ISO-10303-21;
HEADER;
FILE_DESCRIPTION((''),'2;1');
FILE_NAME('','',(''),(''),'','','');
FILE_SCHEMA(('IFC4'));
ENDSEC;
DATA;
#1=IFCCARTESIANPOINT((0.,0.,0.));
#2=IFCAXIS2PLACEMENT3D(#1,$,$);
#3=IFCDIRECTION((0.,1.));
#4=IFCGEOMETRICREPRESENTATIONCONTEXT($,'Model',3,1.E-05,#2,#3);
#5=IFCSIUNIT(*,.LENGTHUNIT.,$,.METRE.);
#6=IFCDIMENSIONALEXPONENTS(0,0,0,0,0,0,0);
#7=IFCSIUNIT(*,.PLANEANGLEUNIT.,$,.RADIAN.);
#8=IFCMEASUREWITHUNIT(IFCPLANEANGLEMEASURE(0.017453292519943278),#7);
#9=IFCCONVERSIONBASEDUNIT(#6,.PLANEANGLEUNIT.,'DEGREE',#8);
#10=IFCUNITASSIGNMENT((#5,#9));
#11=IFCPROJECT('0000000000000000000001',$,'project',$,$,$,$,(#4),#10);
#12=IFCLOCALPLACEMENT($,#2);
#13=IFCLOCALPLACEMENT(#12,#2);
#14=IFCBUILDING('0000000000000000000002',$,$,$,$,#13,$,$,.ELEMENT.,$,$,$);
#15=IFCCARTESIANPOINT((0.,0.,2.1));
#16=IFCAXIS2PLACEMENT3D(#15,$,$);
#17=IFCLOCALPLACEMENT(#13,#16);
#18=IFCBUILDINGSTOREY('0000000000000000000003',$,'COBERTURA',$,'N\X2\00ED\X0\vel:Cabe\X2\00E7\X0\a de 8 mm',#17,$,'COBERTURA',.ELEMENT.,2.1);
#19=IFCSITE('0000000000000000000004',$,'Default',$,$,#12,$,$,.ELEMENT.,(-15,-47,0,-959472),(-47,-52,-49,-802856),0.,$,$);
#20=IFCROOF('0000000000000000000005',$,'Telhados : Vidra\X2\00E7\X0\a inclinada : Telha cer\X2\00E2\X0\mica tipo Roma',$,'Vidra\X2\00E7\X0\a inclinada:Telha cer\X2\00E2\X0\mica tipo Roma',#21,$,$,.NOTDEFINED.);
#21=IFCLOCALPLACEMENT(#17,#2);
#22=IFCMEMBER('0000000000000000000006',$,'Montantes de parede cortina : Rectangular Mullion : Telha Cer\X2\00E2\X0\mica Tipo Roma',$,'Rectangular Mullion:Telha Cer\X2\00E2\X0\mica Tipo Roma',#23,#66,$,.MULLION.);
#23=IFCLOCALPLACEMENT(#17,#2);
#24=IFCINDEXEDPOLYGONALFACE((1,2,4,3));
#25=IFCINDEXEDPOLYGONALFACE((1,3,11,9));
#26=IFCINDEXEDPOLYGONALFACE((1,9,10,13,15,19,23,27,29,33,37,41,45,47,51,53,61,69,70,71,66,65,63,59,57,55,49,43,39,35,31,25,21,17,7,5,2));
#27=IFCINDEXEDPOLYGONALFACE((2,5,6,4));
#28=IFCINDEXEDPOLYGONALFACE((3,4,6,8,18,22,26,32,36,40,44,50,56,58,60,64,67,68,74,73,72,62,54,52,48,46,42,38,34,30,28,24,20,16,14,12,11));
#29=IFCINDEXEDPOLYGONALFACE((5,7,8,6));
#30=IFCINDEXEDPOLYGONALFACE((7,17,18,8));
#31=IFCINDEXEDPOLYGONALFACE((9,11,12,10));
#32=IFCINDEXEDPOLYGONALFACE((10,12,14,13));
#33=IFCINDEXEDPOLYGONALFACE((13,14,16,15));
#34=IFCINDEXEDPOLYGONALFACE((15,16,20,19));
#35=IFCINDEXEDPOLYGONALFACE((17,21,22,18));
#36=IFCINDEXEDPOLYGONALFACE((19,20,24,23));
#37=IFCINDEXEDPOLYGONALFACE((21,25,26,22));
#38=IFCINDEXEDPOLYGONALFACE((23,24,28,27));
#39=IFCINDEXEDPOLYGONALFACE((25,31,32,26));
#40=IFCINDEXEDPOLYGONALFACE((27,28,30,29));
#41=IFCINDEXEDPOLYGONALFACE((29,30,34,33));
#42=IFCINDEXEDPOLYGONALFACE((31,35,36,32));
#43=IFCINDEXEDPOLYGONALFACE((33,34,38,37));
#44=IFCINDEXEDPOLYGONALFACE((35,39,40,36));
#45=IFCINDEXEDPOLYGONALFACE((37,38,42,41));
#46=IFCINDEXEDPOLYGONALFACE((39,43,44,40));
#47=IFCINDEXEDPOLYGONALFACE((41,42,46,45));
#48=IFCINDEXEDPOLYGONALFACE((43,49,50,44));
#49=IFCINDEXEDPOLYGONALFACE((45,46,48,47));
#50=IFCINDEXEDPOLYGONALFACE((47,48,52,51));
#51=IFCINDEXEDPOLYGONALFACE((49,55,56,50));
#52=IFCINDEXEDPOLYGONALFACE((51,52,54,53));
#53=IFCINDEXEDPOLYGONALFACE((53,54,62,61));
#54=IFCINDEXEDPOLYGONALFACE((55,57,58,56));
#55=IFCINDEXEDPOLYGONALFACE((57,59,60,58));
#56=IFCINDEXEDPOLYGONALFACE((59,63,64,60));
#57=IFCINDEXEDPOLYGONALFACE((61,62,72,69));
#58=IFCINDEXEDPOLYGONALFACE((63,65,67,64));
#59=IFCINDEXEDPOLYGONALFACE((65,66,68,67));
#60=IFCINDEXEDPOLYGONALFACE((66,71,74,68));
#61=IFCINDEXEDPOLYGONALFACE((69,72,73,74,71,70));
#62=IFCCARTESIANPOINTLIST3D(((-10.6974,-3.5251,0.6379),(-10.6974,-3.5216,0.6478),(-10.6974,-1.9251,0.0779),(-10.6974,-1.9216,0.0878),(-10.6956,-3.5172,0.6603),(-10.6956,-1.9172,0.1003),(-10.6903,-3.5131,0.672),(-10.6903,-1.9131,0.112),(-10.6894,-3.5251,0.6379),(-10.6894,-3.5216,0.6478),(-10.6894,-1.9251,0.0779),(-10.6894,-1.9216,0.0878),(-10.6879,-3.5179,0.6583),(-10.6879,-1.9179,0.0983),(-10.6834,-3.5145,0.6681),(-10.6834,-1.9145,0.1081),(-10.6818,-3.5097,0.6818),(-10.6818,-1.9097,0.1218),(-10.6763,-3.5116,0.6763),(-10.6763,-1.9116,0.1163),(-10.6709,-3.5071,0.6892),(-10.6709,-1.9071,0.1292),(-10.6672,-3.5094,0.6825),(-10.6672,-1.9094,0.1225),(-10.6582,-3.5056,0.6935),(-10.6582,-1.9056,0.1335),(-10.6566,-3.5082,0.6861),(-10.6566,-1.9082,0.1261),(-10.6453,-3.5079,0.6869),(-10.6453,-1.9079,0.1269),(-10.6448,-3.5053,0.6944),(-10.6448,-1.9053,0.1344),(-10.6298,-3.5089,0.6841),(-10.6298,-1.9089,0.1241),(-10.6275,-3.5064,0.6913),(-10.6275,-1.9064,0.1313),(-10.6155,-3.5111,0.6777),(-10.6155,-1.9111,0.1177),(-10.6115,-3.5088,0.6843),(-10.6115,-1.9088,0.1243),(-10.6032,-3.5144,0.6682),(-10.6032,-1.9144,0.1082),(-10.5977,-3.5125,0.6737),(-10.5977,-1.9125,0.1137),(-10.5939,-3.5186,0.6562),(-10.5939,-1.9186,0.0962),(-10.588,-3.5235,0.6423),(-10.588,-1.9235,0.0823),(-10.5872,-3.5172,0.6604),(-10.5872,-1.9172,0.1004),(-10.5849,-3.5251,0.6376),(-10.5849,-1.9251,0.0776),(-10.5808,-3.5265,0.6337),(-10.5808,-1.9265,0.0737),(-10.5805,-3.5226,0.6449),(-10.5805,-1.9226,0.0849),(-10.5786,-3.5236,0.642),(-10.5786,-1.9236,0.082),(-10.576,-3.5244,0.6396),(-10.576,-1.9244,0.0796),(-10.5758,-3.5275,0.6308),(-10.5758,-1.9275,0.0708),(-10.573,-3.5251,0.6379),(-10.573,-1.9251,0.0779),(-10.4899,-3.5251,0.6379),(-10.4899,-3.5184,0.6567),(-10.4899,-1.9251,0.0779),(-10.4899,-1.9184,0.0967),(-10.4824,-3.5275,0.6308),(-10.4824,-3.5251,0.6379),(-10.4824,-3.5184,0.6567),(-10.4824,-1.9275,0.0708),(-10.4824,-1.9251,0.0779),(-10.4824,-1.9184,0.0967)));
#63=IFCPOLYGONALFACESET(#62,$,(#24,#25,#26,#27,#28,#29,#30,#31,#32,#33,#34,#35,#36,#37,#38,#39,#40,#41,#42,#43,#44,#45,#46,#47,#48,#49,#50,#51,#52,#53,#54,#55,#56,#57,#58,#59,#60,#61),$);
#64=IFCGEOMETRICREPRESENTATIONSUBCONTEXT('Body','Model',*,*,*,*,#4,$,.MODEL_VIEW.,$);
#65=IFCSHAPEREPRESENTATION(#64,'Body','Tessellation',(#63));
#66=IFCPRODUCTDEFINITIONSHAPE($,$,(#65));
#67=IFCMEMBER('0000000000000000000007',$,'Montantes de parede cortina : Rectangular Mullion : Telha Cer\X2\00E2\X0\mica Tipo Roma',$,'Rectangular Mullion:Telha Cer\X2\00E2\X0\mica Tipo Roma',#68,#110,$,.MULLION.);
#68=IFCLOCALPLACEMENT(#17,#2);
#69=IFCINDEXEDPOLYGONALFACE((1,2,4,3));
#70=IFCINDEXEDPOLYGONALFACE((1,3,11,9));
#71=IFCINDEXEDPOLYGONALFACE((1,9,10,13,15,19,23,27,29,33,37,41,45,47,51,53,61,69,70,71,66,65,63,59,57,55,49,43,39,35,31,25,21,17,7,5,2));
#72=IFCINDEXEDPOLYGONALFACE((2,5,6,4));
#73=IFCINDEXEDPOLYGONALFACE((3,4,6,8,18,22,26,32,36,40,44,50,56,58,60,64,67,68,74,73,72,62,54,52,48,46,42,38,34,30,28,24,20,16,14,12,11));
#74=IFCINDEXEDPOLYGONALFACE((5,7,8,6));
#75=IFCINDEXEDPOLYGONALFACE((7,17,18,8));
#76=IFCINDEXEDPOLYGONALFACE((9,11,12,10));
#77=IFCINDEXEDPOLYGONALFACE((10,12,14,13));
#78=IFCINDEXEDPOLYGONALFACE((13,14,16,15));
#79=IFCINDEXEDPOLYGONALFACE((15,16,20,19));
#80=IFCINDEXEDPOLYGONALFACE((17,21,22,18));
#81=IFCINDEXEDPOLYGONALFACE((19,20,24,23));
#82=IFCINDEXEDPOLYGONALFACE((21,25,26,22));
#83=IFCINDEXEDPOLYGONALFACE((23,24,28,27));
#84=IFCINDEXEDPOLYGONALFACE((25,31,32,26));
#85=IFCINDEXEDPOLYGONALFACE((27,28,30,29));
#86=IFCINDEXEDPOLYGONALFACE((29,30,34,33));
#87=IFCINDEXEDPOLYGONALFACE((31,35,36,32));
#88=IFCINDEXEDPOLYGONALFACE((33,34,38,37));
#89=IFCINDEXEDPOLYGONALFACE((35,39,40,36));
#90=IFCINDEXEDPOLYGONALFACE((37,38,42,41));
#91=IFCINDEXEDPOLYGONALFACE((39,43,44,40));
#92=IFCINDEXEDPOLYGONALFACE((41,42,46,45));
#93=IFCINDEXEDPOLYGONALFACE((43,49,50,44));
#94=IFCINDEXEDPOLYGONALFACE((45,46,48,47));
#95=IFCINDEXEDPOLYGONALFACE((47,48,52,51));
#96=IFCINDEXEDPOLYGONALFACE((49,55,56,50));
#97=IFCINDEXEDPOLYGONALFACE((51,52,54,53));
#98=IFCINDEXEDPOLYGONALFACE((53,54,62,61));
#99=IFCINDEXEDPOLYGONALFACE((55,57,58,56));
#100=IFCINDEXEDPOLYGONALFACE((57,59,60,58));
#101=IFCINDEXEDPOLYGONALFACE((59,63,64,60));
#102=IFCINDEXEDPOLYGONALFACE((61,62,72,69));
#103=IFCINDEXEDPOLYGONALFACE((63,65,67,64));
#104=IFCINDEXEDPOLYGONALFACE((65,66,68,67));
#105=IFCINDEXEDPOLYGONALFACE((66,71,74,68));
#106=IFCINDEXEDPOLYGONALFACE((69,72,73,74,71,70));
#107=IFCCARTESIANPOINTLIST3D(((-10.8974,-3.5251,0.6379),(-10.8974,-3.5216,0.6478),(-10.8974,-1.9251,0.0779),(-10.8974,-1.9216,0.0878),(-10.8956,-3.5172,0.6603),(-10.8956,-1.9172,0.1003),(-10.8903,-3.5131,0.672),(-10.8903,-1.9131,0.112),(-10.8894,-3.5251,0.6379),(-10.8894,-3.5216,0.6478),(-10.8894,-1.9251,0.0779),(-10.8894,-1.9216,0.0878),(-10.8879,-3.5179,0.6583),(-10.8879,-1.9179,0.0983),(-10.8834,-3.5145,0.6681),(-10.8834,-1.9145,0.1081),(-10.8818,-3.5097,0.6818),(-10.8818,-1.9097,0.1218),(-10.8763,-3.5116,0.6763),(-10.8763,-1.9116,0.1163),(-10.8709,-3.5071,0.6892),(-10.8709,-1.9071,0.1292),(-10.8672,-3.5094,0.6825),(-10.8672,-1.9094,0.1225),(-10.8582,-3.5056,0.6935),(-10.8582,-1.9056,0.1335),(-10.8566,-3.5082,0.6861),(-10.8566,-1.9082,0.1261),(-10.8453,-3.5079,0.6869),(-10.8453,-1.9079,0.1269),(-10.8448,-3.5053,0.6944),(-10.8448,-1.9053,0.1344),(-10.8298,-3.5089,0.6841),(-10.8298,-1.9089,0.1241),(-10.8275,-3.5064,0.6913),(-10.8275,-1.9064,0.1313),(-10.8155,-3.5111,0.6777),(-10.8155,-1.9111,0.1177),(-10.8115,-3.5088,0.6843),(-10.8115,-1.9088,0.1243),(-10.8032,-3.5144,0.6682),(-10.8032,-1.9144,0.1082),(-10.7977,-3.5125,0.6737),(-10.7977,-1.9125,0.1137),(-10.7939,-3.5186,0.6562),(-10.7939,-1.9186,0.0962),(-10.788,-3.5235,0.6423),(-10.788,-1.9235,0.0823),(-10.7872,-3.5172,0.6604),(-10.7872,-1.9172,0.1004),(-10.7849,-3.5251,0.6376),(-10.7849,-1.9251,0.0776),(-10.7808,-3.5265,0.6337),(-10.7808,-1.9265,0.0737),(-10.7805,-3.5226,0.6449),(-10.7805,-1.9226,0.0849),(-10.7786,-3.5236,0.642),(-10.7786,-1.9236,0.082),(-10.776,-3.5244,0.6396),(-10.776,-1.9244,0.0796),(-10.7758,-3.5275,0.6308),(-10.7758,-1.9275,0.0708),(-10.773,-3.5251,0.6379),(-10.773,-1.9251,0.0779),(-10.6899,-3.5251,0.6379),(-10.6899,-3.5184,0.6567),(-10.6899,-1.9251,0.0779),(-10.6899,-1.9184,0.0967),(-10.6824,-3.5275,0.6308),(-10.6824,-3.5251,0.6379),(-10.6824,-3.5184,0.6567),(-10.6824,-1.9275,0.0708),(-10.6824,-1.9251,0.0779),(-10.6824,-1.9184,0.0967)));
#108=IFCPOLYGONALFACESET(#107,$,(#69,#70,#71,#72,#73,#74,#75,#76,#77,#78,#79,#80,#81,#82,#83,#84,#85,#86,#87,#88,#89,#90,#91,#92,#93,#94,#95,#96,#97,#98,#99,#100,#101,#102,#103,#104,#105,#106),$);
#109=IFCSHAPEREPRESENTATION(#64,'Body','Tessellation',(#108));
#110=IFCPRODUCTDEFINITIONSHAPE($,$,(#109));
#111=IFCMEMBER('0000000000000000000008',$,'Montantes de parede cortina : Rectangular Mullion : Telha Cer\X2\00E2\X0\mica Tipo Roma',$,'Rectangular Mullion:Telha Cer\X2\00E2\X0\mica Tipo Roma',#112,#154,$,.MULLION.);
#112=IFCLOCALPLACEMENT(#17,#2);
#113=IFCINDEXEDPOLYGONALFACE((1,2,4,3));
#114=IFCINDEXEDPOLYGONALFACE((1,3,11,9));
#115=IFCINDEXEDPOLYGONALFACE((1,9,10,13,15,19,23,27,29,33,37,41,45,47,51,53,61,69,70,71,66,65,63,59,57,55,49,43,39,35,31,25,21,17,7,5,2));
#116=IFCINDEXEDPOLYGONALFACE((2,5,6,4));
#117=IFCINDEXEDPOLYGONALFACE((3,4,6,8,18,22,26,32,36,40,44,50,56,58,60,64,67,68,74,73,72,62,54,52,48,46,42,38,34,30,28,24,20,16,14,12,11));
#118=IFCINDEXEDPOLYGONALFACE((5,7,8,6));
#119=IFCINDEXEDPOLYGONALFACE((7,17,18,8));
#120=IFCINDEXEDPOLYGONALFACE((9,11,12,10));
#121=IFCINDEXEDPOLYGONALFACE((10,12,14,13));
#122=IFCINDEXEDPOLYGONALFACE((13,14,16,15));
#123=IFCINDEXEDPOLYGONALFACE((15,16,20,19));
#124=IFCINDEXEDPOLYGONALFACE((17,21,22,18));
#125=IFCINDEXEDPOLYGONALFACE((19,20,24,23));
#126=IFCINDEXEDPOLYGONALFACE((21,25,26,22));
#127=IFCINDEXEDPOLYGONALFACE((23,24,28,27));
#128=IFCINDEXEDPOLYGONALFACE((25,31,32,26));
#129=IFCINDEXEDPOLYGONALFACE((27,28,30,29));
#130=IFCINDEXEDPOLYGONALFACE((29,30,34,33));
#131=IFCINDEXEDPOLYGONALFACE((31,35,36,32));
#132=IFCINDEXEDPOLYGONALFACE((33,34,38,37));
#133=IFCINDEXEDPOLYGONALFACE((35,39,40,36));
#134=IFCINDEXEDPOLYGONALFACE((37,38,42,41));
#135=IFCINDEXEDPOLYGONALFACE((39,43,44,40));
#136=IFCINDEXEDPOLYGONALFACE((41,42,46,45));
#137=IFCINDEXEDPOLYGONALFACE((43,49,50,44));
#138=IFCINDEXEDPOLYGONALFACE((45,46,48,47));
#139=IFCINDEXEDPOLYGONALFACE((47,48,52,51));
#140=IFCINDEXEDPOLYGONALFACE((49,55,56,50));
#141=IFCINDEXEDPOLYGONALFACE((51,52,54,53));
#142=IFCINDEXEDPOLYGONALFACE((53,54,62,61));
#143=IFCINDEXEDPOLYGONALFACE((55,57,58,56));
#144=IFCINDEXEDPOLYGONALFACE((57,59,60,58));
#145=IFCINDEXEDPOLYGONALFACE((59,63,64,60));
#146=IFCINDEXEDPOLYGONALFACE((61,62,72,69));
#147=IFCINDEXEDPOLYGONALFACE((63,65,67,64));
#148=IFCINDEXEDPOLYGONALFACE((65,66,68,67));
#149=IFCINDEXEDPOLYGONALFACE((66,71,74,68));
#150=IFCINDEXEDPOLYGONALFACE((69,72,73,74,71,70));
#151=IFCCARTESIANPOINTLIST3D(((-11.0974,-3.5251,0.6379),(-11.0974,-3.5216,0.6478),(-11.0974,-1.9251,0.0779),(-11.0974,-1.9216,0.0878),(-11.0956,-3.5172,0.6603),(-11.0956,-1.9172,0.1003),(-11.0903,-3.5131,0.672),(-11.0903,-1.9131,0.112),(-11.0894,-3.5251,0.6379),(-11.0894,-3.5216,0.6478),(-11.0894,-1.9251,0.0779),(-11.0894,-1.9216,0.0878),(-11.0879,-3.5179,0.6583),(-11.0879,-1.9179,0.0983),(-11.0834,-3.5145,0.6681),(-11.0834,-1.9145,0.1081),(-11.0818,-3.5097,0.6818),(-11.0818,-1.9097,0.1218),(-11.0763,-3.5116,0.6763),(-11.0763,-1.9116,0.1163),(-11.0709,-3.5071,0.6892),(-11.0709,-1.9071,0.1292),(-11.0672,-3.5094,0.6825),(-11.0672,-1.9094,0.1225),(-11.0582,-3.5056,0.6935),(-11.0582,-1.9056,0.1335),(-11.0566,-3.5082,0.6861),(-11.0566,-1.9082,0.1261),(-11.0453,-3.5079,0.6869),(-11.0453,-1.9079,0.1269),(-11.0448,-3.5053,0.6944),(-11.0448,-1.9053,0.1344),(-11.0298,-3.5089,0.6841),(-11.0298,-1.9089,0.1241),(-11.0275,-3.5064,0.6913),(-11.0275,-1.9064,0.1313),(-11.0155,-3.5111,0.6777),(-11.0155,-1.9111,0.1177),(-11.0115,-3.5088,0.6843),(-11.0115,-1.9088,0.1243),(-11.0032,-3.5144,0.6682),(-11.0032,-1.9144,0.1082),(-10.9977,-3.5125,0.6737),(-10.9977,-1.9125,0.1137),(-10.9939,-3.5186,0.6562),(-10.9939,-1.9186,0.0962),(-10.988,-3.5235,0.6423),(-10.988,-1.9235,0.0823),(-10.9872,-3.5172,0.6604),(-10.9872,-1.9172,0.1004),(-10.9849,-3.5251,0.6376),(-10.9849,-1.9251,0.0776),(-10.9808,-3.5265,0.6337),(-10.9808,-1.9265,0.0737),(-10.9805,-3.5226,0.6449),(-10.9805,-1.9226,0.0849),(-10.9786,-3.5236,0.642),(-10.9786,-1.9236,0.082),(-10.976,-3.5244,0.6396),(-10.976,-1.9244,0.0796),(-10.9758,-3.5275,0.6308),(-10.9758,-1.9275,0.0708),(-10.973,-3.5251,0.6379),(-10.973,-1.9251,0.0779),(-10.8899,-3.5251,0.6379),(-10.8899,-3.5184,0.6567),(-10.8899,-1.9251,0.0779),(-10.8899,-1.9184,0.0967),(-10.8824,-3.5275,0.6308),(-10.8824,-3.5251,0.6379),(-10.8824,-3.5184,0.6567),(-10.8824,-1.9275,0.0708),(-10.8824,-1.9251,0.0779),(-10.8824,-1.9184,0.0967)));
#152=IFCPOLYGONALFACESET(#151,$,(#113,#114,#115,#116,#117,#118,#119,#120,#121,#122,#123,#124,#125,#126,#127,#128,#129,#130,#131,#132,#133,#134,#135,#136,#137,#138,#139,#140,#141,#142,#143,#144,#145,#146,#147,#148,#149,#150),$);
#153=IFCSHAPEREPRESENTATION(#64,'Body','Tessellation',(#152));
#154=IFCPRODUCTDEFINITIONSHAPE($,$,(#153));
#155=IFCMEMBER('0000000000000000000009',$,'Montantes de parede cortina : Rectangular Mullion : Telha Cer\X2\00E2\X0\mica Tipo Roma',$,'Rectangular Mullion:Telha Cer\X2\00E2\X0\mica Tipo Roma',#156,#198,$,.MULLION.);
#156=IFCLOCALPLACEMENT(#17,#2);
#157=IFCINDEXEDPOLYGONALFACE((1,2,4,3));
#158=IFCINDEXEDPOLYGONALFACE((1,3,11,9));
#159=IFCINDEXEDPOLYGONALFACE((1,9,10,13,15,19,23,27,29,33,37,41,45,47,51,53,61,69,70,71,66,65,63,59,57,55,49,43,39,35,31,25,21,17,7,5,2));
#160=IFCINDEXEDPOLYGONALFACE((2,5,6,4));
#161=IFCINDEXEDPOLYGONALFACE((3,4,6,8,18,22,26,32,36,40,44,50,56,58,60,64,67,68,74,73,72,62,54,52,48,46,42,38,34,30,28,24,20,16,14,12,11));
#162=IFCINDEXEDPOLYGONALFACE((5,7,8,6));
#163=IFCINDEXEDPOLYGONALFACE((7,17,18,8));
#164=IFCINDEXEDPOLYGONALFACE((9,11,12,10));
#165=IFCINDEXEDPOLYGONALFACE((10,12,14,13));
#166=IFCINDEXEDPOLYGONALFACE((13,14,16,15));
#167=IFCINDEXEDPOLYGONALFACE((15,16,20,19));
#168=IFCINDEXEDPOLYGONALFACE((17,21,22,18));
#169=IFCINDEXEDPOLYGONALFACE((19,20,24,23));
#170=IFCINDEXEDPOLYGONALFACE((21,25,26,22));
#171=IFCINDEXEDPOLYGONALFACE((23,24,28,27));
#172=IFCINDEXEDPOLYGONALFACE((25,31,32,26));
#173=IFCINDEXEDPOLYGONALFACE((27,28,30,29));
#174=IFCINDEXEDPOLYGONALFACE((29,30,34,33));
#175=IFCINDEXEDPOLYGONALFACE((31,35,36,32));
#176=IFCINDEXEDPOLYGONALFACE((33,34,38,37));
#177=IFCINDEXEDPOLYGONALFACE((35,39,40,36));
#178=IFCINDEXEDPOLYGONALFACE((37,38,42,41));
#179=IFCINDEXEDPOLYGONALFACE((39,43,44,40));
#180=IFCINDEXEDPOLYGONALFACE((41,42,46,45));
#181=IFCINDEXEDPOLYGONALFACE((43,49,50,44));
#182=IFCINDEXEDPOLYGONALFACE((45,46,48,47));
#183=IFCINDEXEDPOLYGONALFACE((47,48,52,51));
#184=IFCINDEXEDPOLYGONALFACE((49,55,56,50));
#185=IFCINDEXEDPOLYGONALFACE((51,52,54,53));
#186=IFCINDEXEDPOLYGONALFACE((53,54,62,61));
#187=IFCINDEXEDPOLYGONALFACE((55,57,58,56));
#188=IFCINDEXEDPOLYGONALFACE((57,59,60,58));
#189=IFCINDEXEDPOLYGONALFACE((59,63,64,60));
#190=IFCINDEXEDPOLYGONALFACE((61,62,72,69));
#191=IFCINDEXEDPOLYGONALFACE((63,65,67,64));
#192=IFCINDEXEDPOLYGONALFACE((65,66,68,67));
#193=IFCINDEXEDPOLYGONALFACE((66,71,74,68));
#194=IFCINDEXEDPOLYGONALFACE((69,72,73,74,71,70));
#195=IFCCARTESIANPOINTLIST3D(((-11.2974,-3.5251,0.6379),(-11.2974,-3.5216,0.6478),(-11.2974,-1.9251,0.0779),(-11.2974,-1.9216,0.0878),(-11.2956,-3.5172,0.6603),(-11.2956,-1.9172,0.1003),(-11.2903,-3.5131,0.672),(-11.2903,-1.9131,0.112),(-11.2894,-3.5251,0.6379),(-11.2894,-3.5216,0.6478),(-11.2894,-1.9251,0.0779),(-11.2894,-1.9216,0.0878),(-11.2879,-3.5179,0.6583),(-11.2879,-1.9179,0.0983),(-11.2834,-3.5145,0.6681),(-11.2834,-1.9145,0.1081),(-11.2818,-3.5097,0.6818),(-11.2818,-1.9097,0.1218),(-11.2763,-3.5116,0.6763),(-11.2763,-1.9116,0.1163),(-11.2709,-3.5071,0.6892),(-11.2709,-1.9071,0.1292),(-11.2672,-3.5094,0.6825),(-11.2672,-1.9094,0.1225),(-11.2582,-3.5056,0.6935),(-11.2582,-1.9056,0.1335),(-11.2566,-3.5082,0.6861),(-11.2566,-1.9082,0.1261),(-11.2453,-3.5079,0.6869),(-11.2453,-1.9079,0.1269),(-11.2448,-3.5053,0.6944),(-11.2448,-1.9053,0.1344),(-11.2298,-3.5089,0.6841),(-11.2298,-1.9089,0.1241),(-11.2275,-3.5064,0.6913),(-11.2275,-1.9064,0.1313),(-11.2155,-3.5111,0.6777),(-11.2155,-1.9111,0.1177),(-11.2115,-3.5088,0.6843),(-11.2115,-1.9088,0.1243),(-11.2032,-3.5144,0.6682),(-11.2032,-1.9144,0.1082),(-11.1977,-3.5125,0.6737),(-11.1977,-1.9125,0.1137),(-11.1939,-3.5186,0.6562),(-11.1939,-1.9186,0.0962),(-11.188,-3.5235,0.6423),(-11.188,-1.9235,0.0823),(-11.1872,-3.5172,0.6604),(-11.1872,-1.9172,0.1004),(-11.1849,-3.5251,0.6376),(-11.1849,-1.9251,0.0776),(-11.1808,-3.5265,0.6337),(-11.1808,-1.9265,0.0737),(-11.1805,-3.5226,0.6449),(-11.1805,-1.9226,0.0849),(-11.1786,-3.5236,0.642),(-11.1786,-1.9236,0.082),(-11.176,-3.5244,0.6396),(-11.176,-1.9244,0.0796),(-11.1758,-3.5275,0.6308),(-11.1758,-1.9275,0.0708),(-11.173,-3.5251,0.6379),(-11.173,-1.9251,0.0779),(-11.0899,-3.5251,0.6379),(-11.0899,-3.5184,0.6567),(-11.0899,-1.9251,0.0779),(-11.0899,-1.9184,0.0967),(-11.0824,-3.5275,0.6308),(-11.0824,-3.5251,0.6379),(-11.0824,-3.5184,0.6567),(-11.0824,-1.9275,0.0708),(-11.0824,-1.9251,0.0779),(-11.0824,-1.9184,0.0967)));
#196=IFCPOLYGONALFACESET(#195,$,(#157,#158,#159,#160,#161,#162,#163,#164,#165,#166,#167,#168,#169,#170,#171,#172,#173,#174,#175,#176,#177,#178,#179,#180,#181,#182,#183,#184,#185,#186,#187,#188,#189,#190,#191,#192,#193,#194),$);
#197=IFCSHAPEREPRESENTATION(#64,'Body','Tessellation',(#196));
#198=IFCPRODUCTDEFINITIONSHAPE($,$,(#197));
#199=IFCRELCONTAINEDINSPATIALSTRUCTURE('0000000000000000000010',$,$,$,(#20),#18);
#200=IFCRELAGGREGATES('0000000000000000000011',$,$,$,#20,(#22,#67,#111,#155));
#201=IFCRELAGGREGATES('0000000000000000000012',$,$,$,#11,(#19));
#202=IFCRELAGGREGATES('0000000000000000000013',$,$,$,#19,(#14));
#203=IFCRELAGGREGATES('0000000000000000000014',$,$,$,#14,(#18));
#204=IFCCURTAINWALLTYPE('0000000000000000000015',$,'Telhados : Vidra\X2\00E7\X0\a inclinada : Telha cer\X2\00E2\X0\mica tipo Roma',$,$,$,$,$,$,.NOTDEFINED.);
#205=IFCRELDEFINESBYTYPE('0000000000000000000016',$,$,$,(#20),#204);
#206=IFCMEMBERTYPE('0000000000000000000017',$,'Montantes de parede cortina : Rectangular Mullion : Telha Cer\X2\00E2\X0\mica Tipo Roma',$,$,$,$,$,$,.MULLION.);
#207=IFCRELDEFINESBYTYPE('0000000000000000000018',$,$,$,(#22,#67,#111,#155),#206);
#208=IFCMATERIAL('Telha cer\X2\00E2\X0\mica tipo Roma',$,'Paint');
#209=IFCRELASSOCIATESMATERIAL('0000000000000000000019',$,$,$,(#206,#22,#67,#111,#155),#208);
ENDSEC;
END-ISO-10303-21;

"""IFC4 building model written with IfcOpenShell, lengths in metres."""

from ifc_helpers import new_model, entity, si_unit, converted_unit, direction, frame, origin, place, context, subcontext, project, spatial, line, arc, indexed_curve, outline, extrude, source, transform, mapped, material, type_object, type_shapes, element, aggregate, save


model = new_model("IFC4")

# Units and contexts
model_context = context("Model", 3, precision=1e-05, world=origin(), true_north=direction((0.0, 1.0)))
body_context = subcontext(model_context, "Body", "Model", "MODEL_VIEW")
ifc_project = project(units=[si_unit("LENGTHUNIT", "METRE"), converted_unit("PLANEANGLEUNIT", "DEGREE", entity("IfcPlaneAngleMeasure", 0.017453292519943278), si_unit("PLANEANGLEUNIT", "RADIAN"), dimensions=[0, 0, 0, 0, 0, 0, 0])], contexts=[model_context])

# Site, building, storey
site_placement = place(None, origin())
site = spatial("IfcSite", under=ifc_project, at=site_placement, Name="Default", CompositionType="ELEMENT", RefLatitude=(-15, -47, 0, -959472), RefLongitude=(-47, -52, -49, -802856), RefElevation=0.0)
building_placement = place(site_placement, origin())
building = spatial("IfcBuilding", under=site, at=building_placement, CompositionType="ELEMENT")
storey_placement = place(building_placement, frame((0.0, 0.0, 2.1)))
storey = spatial("IfcBuildingStorey", under=building, at=storey_placement, Name="COBERTURA", ObjectType="Nível:Cabeça de 8 mm", LongName="COBERTURA", CompositionType="ELEMENT", Elevation=2.1)

# Roof, members
curtain_wall_type_1 = type_object("IfcCurtainWallType", Name="Telhados : Vidraça inclinada : Telha cerâmica tipo Roma", PredefinedType="NOTDEFINED")
roof_1_placement = place(storey_placement, frame((0.0, 0.0, -2.1)))
roof_1 = element("IfcRoof", 1, at=roof_1_placement, inside=storey, type_object=curtain_wall_type_1, Name="Telhados : Vidraça inclinada : Telha cerâmica tipo Roma", ObjectType="Vidraça inclinada:Telha cerâmica tipo Roma", PredefinedType="NOTDEFINED")
ifc_material_1 = material(Name="Telha cerâmica tipo Roma", Category="Paint")
member_type_1 = type_object("IfcMemberType", Name="Montantes de parede cortina : Rectangular Mullion : Telha Cerâmica Tipo Roma", PredefinedType="MULLION", material=ifc_material_1)
shared_shape_1 = source(origin(), body_context, "Body", "SweptSolid", [
    extrude(outline(indexed_curve([(0.0114, -0.0188), (0.1048, -0.0188), (0.1048, -0.0113), (0.1048, 0.0087), (0.0973, 0.0087), (0.0973, -0.0113), (0.0142, -0.0113), (0.0098, -0.0083), (0.0067, -0.0038), (-0.017, 0.0327), (-0.0576, 0.0486), (-0.0946, 0.0352), (-0.1102, -0.0008), (-0.1102, -0.0113), (-0.1022, -0.0113), (-0.1022, -0.0008), (-0.0891, 0.0294), (-0.0581, 0.0406), (-0.0218, 0.0263), (-0.0008, -0.0066), (0.0042, -0.0138)], segments=[line(1, 2, 3, 4, 5, 6, 7), arc(7, 8, 9), arc(9, 10, 11), arc(11, 12, 13), line(13, 14, 15, 16), arc(16, 17, 18), arc(18, 19, 20), arc(20, 21, 1)], self_intersect=False)), frame((-0.0027, -0.0938, -4.3552), z_axis=(0.0, 0.0, 1.0), x_axis=(-1.0, 0.0, 0.0)), (0.0, 0.0, 1.0), 1.6952),
])
type_shapes(member_type_1, [shared_shape_1])
member_1_placement = place(roof_1_placement, frame((-10.5899, -6.063, 3.5387), z_axis=(0.0, -0.943858, 0.33035), x_axis=(-1.0, 0.0, 0.0)))
member_1 = element("IfcMember", 2, at=member_1_placement, type_object=member_type_1, material=ifc_material_1, Name="Montantes de parede cortina : Rectangular Mullion : Telha Cerâmica Tipo Roma", ObjectType="Rectangular Mullion:Telha Cerâmica Tipo Roma", PredefinedType="MULLION", context=body_context, shape_type="MappedRepresentation", body=[
    mapped(shared_shape_1, transform((0.0, 0.0, 0.0), scale=1.0)),
])
member_2_placement = place(roof_1_placement, frame((-10.7899, -6.063, 3.5387), z_axis=(0.0, -0.943858, 0.33035), x_axis=(-1.0, 0.0, 0.0)))
member_2 = element("IfcMember", 3, at=member_2_placement, type_object=member_type_1, material=ifc_material_1, Name="Montantes de parede cortina : Rectangular Mullion : Telha Cerâmica Tipo Roma", ObjectType="Rectangular Mullion:Telha Cerâmica Tipo Roma", PredefinedType="MULLION", context=body_context, shape_type="MappedRepresentation", body=[
    mapped(shared_shape_1, transform((0.0, 0.0, 0.0), scale=1.0)),
])
member_3_placement = place(roof_1_placement, frame((-10.9899, -6.063, 3.5387), z_axis=(0.0, -0.943858, 0.33035), x_axis=(-1.0, 0.0, 0.0)))
member_3 = element("IfcMember", 4, at=member_3_placement, type_object=member_type_1, material=ifc_material_1, Name="Montantes de parede cortina : Rectangular Mullion : Telha Cerâmica Tipo Roma", ObjectType="Rectangular Mullion:Telha Cerâmica Tipo Roma", PredefinedType="MULLION", context=body_context, shape_type="MappedRepresentation", body=[
    mapped(shared_shape_1, transform((0.0, 0.0, 0.0), scale=1.0)),
])
member_4_placement = place(roof_1_placement, frame((-11.1899, -6.063, 3.5387), z_axis=(0.0, -0.943858, 0.33035), x_axis=(-1.0, 0.0, 0.0)))
member_4 = element("IfcMember", 5, at=member_4_placement, type_object=member_type_1, material=ifc_material_1, Name="Montantes de parede cortina : Rectangular Mullion : Telha Cerâmica Tipo Roma", ObjectType="Rectangular Mullion:Telha Cerâmica Tipo Roma", PredefinedType="MULLION", context=body_context, shape_type="MappedRepresentation", body=[
    mapped(shared_shape_1, transform((0.0, 0.0, 0.0), scale=1.0)),
])
aggregate(roof_1, [member_1, member_2, member_3, member_4])

save(model, "model.ifc")
